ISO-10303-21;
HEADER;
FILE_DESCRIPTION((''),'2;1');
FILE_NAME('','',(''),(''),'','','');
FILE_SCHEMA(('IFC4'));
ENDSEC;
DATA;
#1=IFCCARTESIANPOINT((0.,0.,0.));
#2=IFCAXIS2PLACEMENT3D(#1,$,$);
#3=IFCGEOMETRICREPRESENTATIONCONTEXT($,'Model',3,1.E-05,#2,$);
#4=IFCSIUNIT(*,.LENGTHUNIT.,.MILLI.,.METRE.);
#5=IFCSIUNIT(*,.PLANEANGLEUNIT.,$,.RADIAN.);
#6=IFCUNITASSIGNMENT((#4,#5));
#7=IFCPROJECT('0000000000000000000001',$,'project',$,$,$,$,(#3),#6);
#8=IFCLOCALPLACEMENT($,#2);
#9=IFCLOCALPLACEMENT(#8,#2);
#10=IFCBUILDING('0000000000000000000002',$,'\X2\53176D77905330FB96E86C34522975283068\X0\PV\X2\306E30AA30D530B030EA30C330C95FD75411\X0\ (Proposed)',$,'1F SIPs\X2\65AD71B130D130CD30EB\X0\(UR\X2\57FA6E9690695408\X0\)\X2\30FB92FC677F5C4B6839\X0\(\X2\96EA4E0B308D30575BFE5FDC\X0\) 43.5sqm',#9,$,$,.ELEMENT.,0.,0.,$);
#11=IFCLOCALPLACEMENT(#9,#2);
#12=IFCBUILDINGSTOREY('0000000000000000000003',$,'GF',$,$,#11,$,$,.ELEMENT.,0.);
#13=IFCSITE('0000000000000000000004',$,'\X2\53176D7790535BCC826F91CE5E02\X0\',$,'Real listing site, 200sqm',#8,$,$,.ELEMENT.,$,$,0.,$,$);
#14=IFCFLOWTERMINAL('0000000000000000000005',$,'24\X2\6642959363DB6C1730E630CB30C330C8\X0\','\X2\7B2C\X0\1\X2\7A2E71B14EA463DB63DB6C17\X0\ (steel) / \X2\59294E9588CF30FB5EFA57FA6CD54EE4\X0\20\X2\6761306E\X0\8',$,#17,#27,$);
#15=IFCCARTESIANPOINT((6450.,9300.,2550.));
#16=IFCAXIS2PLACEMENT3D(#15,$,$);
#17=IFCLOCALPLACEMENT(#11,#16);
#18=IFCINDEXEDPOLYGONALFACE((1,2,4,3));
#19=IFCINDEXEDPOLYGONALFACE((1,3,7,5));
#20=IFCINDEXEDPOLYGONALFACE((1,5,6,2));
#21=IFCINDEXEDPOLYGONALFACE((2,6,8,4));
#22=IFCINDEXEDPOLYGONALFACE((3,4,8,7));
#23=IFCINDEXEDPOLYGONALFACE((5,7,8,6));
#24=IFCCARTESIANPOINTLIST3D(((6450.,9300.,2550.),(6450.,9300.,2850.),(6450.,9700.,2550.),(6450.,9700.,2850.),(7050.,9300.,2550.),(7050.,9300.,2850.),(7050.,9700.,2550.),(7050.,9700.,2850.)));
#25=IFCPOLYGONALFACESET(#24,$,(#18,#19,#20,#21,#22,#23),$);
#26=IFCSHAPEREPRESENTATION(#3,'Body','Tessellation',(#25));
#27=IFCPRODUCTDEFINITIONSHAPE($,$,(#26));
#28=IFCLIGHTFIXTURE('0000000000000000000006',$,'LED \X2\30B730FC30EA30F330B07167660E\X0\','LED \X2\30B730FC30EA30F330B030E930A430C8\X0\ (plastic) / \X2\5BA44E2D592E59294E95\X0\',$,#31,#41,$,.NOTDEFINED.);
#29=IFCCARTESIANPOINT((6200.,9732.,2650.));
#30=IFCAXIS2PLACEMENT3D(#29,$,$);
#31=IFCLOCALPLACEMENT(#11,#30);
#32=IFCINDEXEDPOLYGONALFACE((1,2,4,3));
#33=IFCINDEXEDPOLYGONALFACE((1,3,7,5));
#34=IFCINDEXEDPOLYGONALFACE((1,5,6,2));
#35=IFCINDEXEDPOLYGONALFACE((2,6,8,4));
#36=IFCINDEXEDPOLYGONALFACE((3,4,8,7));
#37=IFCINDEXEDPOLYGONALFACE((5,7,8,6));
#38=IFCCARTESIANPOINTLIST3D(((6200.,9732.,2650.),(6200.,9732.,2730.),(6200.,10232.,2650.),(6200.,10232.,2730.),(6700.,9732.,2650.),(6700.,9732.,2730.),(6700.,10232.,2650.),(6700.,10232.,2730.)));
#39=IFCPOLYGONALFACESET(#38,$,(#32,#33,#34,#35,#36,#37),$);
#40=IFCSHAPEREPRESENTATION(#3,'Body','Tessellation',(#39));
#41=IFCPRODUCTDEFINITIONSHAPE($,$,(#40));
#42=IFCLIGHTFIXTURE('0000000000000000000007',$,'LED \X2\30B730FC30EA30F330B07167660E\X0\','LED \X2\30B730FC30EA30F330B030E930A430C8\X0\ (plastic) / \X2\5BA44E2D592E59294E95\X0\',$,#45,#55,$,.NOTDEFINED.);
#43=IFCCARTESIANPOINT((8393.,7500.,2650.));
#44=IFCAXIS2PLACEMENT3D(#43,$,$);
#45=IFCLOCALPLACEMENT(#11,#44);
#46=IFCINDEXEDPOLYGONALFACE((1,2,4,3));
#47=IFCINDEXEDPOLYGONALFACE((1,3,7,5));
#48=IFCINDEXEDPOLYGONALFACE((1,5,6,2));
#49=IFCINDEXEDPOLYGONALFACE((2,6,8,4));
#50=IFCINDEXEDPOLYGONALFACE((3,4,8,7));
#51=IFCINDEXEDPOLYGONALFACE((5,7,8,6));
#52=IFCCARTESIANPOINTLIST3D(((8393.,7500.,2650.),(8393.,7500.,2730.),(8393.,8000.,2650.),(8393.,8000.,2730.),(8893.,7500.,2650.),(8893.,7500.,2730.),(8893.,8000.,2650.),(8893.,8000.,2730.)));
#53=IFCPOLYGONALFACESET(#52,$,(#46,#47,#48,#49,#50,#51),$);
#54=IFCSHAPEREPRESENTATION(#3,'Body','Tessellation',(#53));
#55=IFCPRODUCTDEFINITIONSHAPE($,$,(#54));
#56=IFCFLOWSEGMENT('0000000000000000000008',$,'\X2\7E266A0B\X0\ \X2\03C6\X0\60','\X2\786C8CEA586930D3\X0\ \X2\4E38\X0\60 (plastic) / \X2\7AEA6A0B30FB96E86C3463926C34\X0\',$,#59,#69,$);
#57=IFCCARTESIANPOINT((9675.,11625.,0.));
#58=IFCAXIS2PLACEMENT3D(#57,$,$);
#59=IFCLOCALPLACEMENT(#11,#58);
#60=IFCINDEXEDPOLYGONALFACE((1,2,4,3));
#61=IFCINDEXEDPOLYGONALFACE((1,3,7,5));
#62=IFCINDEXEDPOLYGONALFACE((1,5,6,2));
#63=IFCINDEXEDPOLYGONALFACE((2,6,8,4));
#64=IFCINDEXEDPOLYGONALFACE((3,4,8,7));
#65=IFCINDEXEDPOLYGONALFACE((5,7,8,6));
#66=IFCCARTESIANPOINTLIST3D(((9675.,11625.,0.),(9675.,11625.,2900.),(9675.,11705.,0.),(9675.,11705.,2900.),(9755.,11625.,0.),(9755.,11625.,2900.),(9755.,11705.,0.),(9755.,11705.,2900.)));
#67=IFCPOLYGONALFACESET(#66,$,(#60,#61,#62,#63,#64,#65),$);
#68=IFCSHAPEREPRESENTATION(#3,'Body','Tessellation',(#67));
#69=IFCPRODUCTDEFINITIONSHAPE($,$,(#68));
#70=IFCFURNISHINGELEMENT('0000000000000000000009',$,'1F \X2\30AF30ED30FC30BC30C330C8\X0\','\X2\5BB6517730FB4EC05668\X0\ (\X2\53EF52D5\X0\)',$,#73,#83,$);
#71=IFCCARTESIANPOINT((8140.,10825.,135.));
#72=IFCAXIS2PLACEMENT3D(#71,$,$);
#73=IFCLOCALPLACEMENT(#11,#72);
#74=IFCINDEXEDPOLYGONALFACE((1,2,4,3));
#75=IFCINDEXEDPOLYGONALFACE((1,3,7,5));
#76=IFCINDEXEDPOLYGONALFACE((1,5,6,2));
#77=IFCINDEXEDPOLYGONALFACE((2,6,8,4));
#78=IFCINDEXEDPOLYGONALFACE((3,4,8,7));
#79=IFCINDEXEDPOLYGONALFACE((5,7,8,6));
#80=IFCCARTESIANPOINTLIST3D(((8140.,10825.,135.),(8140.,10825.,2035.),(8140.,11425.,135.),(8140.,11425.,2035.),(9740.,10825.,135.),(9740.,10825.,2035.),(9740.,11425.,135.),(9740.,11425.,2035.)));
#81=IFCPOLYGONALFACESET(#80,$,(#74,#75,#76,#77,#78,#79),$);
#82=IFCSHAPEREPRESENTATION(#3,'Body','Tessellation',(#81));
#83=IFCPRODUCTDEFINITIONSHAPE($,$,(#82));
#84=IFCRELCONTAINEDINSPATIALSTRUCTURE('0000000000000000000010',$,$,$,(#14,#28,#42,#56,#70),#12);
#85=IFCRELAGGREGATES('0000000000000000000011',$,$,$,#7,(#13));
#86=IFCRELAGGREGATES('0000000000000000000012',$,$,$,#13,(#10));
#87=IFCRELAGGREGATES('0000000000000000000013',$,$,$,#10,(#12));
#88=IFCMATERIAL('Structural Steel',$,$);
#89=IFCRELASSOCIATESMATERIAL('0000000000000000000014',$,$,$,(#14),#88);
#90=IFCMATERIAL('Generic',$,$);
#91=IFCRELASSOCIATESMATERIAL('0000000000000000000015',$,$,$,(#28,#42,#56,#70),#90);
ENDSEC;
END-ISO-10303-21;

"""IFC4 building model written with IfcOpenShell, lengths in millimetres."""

from ifc_helpers import new_model, si_unit, frame, frame_2d, origin, place, context, project, spatial, rectangle, extrude, material, element, save


model = new_model("IFC4")

# Units and contexts
model_context = context("Model", 3, precision=1e-05, world=origin())
ifc_project = project(units=[si_unit("LENGTHUNIT", "METRE", prefix="MILLI"), si_unit("PLANEANGLEUNIT", "RADIAN")], contexts=[model_context])

# Site, building, storey
site_placement = place(None, origin())
site = spatial("IfcSite", under=ifc_project, at=site_placement, Name="北海道富良野市", ObjectType="Real listing site, 200sqm", CompositionType="ELEMENT", RefElevation=0.0)
building_placement = place(site_placement, origin())
building = spatial("IfcBuilding", under=site, at=building_placement, Name="北海道・雨水利用とPVのオフグリッド志向 (Proposed)", ObjectType="1F SIPs断熱パネル(UR基準適合)・鋼板屋根(雪下ろし対応) 43.5sqm", CompositionType="ELEMENT", ElevationOfRefHeight=0.0, ElevationOfTerrain=0.0)
storey_placement = place(building_placement, origin())
storey = spatial("IfcBuildingStorey", under=building, at=storey_placement, Name="GF", CompositionType="ELEMENT", Elevation=0.0)

# Shared definitions
ifc_material_1 = material(Name="Generic")

# Flow terminal
ifc_material_2 = material(Name="Structural Steel")
flow_terminal_placement = place(storey_placement, frame((6450.0, 9300.0, 2550.0)))
element("IfcFlowTerminal", 1, at=flow_terminal_placement, inside=storey, material=ifc_material_2, Name="24時間換気ユニット", Description="第1種熱交換換気 (steel) / 天井裏・建基法令20条の8", context=model_context, shape_type="SweptSolid", body=[
    extrude(rectangle(XDim=600.0, YDim=400.0, at=frame_2d((300.0, 200.0))), frame((6450.0, 9300.0, 2550.0)), (0.0, 0.0, 1.0), 300.0),
])

# Light fixtures
light_fixture_1_placement = place(storey_placement, frame((6200.0, 9732.0, 2650.0)))
element("IfcLightFixture", 2, at=light_fixture_1_placement, inside=storey, material=ifc_material_1, Name="LED シーリング照明", Description="LED シーリングライト (plastic) / 室中央天井", PredefinedType="NOTDEFINED", context=model_context, shape_type="SweptSolid", body=[
    extrude(rectangle(XDim=500.0, YDim=500.0, at=frame_2d((250.0, 250.0))), frame((6200.0, 9732.0, 2650.0)), (0.0, 0.0, 1.0), 80.0),
])
light_fixture_2_placement = place(storey_placement, frame((8393.0, 7500.0, 2650.0)))
element("IfcLightFixture", 3, at=light_fixture_2_placement, inside=storey, material=ifc_material_1, Name="LED シーリング照明", Description="LED シーリングライト (plastic) / 室中央天井", PredefinedType="NOTDEFINED", context=model_context, shape_type="SweptSolid", body=[
    extrude(rectangle(XDim=500.0, YDim=500.0, at=frame_2d((250.0, 250.0))), frame((8393.0, 7500.0, 2650.0)), (0.0, 0.0, 1.0), 80.0),
])

# Flow segment
flow_segment_placement = place(storey_placement, frame((9675.0, 11625.0, 0.0)))
element("IfcFlowSegment", 4, at=flow_segment_placement, inside=storey, material=ifc_material_1, Name="縦樋 φ60", Description="硬質塩ビ 丸60 (plastic) / 竪樋・雨水排水", context=model_context, shape_type="SweptSolid", body=[
    extrude(rectangle(XDim=80.0, YDim=80.0, at=frame_2d((40.0, 40.0))), frame((9675.0, 11625.0, 0.0)), (0.0, 0.0, 1.0), 2900.0),
])

# Furnishing element
furnishing_placement = place(storey_placement, frame((8140.0, 10825.0, 135.0)))
element("IfcFurnishingElement", 5, at=furnishing_placement, inside=storey, material=ifc_material_1, Name="1F クローゼット", Description="家具・什器 (可動)", context=model_context, shape_type="SweptSolid", body=[
    extrude(rectangle(XDim=1600.0, YDim=600.0, at=frame_2d((800.0, 300.0))), frame((8140.0, 10825.0, 135.0)), (0.0, 0.0, 1.0), 1900.0),
])

save(model, "model.ifc")
